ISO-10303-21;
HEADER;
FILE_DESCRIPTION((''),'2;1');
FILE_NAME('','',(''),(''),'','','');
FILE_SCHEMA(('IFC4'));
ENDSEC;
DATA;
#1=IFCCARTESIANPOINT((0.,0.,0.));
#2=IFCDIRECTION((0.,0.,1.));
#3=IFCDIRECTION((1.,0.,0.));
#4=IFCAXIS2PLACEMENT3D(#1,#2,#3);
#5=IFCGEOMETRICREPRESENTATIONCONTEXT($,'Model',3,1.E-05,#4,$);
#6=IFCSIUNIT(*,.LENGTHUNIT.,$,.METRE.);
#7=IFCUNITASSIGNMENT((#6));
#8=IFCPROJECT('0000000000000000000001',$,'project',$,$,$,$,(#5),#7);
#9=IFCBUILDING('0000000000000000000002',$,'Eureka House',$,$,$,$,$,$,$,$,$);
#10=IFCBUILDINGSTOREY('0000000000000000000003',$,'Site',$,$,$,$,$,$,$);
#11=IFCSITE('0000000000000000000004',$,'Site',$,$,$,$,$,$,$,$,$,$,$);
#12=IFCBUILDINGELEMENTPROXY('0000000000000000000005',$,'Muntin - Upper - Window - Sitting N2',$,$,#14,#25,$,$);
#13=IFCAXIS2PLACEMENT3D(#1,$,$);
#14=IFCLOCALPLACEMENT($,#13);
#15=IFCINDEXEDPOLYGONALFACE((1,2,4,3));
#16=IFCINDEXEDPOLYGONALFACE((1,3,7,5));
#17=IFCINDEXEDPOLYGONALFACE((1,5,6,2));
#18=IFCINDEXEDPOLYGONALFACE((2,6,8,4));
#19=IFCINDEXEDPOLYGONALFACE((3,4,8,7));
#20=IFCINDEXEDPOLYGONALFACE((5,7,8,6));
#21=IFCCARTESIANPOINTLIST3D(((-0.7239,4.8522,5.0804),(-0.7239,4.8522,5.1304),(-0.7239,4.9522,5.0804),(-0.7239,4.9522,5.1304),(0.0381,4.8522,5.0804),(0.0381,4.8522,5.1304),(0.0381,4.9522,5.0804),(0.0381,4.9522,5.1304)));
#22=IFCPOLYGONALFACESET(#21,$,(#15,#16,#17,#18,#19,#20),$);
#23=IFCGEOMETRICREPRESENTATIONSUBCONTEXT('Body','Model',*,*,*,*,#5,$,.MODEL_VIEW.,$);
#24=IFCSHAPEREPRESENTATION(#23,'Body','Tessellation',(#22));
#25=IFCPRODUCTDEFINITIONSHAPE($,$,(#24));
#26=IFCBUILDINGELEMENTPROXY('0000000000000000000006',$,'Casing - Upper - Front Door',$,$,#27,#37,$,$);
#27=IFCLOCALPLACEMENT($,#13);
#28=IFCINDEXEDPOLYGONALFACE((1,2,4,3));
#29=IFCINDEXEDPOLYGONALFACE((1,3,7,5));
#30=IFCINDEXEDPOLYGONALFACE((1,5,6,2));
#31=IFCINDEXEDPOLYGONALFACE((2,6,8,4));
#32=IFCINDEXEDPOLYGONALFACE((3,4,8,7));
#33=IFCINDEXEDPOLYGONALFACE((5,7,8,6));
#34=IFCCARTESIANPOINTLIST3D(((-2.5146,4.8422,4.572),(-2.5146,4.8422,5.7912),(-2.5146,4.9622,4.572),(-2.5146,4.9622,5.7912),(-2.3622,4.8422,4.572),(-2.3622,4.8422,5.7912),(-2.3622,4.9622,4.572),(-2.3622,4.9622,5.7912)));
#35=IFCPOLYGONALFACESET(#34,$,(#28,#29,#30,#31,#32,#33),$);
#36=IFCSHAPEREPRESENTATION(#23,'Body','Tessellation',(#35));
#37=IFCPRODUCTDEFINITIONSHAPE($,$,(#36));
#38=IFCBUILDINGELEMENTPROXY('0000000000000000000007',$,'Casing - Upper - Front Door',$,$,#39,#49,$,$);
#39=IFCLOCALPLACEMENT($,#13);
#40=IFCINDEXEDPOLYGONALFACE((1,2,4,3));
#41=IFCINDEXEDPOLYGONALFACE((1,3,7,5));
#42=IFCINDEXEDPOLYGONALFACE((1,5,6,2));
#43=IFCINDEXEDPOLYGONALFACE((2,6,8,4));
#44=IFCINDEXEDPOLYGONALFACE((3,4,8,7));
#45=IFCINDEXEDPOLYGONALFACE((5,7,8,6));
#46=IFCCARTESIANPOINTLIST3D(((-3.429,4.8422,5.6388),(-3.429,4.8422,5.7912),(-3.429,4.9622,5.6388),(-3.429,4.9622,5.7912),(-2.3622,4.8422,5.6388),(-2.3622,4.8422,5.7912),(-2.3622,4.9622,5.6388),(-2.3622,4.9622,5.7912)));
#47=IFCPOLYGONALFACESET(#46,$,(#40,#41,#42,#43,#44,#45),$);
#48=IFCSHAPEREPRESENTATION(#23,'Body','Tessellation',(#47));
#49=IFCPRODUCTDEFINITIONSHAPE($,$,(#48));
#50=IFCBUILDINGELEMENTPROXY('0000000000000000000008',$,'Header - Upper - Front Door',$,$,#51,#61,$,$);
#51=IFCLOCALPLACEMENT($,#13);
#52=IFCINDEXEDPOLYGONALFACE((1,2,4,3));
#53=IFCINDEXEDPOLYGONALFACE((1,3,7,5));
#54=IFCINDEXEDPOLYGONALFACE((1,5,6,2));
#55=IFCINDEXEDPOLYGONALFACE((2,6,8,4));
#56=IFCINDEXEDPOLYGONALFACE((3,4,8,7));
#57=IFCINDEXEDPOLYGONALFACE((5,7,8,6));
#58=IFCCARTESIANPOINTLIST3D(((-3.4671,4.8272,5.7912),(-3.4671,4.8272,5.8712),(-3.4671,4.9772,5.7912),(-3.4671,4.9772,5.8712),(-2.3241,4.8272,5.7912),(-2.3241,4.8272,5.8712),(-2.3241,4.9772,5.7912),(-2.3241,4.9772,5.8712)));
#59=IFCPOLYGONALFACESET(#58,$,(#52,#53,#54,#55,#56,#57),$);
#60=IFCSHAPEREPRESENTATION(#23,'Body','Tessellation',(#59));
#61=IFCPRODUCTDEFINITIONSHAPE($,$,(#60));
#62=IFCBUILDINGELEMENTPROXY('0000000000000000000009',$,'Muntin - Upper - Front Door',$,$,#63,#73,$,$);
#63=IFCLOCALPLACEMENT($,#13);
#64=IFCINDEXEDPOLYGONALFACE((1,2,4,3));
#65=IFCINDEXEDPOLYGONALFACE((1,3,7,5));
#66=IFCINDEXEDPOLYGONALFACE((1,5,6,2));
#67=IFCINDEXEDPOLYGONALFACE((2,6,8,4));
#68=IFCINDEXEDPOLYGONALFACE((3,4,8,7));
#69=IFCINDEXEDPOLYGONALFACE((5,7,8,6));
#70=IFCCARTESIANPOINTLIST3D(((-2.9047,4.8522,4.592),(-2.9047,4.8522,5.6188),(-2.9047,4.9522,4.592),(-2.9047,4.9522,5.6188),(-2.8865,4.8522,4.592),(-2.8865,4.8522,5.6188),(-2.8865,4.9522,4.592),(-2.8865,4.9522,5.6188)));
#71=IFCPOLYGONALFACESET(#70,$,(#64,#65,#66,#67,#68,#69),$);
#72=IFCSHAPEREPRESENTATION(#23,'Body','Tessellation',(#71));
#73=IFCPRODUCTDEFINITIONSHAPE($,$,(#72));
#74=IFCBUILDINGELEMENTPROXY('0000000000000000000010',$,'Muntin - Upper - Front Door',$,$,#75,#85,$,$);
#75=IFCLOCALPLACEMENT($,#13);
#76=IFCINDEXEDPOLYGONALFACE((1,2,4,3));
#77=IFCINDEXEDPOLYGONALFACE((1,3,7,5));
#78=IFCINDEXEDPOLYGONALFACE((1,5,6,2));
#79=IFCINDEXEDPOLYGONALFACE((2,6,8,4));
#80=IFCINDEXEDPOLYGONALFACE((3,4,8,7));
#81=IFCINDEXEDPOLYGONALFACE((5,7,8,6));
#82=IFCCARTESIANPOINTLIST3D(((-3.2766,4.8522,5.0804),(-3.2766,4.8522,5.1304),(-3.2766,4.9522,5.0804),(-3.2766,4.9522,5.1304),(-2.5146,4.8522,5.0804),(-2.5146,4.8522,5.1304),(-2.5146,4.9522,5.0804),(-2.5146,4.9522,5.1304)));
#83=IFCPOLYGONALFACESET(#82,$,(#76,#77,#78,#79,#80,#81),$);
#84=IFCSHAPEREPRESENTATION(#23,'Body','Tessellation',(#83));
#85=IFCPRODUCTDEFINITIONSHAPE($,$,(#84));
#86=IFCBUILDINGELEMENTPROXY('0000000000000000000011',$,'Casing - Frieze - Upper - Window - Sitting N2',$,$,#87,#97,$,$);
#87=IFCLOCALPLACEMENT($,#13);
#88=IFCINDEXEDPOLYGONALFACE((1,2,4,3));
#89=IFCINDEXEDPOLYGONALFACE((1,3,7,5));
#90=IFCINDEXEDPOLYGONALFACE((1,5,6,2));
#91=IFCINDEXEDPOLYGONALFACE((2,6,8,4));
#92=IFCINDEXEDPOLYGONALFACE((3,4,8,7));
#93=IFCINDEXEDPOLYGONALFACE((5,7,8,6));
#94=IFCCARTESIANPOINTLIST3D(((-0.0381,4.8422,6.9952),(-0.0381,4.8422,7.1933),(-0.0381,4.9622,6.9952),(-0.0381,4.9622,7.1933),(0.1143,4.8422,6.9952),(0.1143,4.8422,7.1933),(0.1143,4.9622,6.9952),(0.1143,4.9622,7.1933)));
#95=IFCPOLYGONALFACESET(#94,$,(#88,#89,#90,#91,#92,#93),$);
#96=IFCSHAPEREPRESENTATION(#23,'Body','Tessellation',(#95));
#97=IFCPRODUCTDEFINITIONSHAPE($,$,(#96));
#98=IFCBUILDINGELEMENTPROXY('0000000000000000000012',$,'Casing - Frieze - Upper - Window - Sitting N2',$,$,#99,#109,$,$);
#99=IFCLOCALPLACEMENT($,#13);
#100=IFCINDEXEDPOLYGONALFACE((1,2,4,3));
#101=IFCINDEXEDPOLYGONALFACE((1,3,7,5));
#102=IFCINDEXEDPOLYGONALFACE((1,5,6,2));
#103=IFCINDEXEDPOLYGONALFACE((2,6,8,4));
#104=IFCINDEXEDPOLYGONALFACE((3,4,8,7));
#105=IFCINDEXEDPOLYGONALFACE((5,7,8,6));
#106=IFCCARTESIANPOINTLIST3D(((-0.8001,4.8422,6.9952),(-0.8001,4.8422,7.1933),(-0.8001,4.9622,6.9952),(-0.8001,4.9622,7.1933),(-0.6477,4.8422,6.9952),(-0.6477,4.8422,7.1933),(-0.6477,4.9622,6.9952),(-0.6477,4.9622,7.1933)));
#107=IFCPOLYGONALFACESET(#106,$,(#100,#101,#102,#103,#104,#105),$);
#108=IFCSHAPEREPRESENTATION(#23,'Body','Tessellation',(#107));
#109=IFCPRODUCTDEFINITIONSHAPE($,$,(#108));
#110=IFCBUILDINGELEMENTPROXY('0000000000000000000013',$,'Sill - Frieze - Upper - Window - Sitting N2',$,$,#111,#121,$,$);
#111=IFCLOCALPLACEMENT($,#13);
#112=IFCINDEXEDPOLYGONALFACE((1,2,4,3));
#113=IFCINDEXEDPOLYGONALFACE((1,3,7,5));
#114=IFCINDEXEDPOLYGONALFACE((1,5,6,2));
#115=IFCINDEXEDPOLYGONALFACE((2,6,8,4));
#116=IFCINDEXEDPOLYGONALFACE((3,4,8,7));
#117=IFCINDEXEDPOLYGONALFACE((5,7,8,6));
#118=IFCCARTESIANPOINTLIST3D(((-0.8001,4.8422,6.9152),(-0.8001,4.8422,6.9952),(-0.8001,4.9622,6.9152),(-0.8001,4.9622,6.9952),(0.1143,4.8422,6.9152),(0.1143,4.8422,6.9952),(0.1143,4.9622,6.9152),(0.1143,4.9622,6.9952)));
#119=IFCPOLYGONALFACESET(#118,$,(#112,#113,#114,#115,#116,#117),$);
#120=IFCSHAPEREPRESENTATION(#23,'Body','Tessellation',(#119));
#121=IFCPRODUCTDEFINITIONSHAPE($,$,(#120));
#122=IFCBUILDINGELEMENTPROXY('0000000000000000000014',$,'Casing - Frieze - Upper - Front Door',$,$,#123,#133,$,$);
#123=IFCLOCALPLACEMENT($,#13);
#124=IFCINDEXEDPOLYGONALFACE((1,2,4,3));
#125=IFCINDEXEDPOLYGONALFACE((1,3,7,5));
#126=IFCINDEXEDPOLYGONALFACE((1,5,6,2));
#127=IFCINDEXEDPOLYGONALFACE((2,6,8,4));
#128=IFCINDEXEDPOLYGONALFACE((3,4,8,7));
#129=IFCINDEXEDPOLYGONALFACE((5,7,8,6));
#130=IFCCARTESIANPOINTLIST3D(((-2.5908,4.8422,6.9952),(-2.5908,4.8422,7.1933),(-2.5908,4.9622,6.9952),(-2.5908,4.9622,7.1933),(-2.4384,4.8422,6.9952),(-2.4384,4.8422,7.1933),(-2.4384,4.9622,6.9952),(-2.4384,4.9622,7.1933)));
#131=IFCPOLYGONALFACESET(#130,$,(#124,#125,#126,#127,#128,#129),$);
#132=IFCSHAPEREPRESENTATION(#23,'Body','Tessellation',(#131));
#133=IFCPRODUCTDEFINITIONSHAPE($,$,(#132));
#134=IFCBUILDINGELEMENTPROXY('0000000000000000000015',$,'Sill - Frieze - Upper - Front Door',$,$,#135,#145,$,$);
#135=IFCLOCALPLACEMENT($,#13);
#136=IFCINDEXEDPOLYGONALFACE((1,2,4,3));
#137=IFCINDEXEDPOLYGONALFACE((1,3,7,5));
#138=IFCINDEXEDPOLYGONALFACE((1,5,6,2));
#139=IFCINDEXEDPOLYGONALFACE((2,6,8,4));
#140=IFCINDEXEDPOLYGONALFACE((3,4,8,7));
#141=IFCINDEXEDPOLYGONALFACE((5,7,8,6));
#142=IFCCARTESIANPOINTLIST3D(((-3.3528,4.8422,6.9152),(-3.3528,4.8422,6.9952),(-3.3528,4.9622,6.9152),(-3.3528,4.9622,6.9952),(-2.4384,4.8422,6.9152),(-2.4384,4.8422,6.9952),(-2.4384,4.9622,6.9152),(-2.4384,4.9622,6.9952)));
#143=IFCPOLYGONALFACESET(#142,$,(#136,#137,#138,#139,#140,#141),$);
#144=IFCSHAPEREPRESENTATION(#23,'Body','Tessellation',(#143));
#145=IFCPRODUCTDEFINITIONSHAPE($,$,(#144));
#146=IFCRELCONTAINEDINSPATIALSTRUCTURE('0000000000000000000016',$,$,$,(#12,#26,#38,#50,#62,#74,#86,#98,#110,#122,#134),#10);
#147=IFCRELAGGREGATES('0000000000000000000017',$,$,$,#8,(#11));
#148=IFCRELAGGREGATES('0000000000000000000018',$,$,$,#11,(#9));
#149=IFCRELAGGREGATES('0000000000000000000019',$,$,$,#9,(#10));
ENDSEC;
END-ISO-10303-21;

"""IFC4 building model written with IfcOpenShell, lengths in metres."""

from ifc_helpers import new_model, si_unit, frame, origin, origin_with_axes, origin_2d, place, context, subcontext, project, spatial, rectangle, extrude, element, save


model = new_model("IFC4")

# Units and contexts
model_context = context("Model", 3, precision=1e-05, world=origin_with_axes())
body_context = subcontext(model_context, "Body", "Model", "MODEL_VIEW")
ifc_project = project(units=[si_unit("LENGTHUNIT", "METRE")], contexts=[model_context])

# Site, building, storey
site = spatial("IfcSite", under=ifc_project, Name="Site")
building = spatial("IfcBuilding", under=site, Name="Eureka House")
storey = spatial("IfcBuildingStorey", under=building, Name="Site")

# Building element proxies
proxy_1_placement = place(None, frame((-0.3429, 4.9022, 5.0804), z_axis=(0.0, 0.0, 1.0), x_axis=(1.0, 0.0, 0.0)))
element("IfcBuildingElementProxy", 1, at=proxy_1_placement, inside=storey, Name="Muntin - Upper - Window - Sitting N2", context=body_context, shape_type="SweptSolid", body=[
    extrude(rectangle(XDim=0.762, YDim=0.1, at=origin_2d()), origin(), (0.0, 0.0, 1.0), 0.05),
])
proxy_2_placement = place(None, frame((-2.4384, 4.9022, 4.572), z_axis=(0.0, 0.0, 1.0), x_axis=(1.0, 0.0, 0.0)))
element("IfcBuildingElementProxy", 2, at=proxy_2_placement, inside=storey, Name="Casing - Upper - Front Door", context=body_context, shape_type="SweptSolid", body=[
    extrude(rectangle(XDim=0.1524, YDim=0.12, at=origin_2d()), origin(), (0.0, 0.0, 1.0), 1.2192),
])
proxy_3_placement = place(None, frame((-2.8956, 4.9022, 5.6388), z_axis=(0.0, 0.0, 1.0), x_axis=(1.0, 0.0, 0.0)))
element("IfcBuildingElementProxy", 3, at=proxy_3_placement, inside=storey, Name="Casing - Upper - Front Door", context=body_context, shape_type="SweptSolid", body=[
    extrude(rectangle(XDim=1.0668, YDim=0.12, at=origin_2d()), origin(), (0.0, 0.0, 1.0), 0.1524),
])
proxy_4_placement = place(None, frame((-2.8956, 4.9022, 5.7912), z_axis=(0.0, 0.0, 1.0), x_axis=(1.0, 0.0, 0.0)))
element("IfcBuildingElementProxy", 4, at=proxy_4_placement, inside=storey, Name="Header - Upper - Front Door", context=body_context, shape_type="SweptSolid", body=[
    extrude(rectangle(XDim=1.143, YDim=0.15, at=origin_2d()), origin(), (0.0, 0.0, 1.0), 0.08),
])
proxy_5_placement = place(None, frame((-2.8956, 4.9022, 4.592), z_axis=(0.0, 0.0, 1.0), x_axis=(1.0, 0.0, 0.0)))
element("IfcBuildingElementProxy", 5, at=proxy_5_placement, inside=storey, Name="Muntin - Upper - Front Door", context=body_context, shape_type="SweptSolid", body=[
    extrude(rectangle(XDim=0.0183, YDim=0.1, at=origin_2d()), origin(), (0.0, 0.0, 1.0), 1.0268),
])
proxy_6_placement = place(None, frame((-2.8956, 4.9022, 5.0804), z_axis=(0.0, 0.0, 1.0), x_axis=(1.0, 0.0, 0.0)))
element("IfcBuildingElementProxy", 6, at=proxy_6_placement, inside=storey, Name="Muntin - Upper - Front Door", context=body_context, shape_type="SweptSolid", body=[
    extrude(rectangle(XDim=0.762, YDim=0.1, at=origin_2d()), origin(), (0.0, 0.0, 1.0), 0.05),
])
for number, where, z_axis, x_axis, name in (
    (7, (0.0381, 4.9022, 6.9952), (0.0, 0.0, 1.0), (1.0, 0.0, 0.0), "Casing - Frieze - Upper - Window - Sitting N2"),
    (8, (-0.7239, 4.9022, 6.9952), (0.0, 0.0, 1.0), (1.0, 0.0, 0.0), "Casing - Frieze - Upper - Window - Sitting N2"),
):
    element("IfcBuildingElementProxy", number, at=place(None, frame(where, z_axis=z_axis, x_axis=x_axis)), inside=storey, Name=name, context=body_context, shape_type="SweptSolid", body=[
        extrude(rectangle(XDim=0.1524, YDim=0.12, at=origin_2d()), origin(), (0.0, 0.0, 1.0), 0.1981),
    ])
proxy_7_placement = place(None, frame((-0.3429, 4.9022, 6.9152), z_axis=(0.0, 0.0, 1.0), x_axis=(1.0, 0.0, 0.0)))
element("IfcBuildingElementProxy", 9, at=proxy_7_placement, inside=storey, Name="Sill - Frieze - Upper - Window - Sitting N2", context=body_context, shape_type="SweptSolid", body=[
    extrude(rectangle(XDim=0.9144, YDim=0.12, at=origin_2d()), origin(), (0.0, 0.0, 1.0), 0.08),
])
proxy_8_placement = place(None, frame((-2.5146, 4.9022, 6.9952), z_axis=(0.0, 0.0, 1.0), x_axis=(1.0, 0.0, 0.0)))
element("IfcBuildingElementProxy", 10, at=proxy_8_placement, inside=storey, Name="Casing - Frieze - Upper - Front Door", context=body_context, shape_type="SweptSolid", body=[
    extrude(rectangle(XDim=0.1524, YDim=0.12, at=origin_2d()), origin(), (0.0, 0.0, 1.0), 0.1981),
])
proxy_9_placement = place(None, frame((-2.8956, 4.9022, 6.9152), z_axis=(0.0, 0.0, 1.0), x_axis=(1.0, 0.0, 0.0)))
element("IfcBuildingElementProxy", 11, at=proxy_9_placement, inside=storey, Name="Sill - Frieze - Upper - Front Door", context=body_context, shape_type="SweptSolid", body=[
    extrude(rectangle(XDim=0.9144, YDim=0.12, at=origin_2d()), origin(), (0.0, 0.0, 1.0), 0.08),
])

save(model, "model.ifc")
